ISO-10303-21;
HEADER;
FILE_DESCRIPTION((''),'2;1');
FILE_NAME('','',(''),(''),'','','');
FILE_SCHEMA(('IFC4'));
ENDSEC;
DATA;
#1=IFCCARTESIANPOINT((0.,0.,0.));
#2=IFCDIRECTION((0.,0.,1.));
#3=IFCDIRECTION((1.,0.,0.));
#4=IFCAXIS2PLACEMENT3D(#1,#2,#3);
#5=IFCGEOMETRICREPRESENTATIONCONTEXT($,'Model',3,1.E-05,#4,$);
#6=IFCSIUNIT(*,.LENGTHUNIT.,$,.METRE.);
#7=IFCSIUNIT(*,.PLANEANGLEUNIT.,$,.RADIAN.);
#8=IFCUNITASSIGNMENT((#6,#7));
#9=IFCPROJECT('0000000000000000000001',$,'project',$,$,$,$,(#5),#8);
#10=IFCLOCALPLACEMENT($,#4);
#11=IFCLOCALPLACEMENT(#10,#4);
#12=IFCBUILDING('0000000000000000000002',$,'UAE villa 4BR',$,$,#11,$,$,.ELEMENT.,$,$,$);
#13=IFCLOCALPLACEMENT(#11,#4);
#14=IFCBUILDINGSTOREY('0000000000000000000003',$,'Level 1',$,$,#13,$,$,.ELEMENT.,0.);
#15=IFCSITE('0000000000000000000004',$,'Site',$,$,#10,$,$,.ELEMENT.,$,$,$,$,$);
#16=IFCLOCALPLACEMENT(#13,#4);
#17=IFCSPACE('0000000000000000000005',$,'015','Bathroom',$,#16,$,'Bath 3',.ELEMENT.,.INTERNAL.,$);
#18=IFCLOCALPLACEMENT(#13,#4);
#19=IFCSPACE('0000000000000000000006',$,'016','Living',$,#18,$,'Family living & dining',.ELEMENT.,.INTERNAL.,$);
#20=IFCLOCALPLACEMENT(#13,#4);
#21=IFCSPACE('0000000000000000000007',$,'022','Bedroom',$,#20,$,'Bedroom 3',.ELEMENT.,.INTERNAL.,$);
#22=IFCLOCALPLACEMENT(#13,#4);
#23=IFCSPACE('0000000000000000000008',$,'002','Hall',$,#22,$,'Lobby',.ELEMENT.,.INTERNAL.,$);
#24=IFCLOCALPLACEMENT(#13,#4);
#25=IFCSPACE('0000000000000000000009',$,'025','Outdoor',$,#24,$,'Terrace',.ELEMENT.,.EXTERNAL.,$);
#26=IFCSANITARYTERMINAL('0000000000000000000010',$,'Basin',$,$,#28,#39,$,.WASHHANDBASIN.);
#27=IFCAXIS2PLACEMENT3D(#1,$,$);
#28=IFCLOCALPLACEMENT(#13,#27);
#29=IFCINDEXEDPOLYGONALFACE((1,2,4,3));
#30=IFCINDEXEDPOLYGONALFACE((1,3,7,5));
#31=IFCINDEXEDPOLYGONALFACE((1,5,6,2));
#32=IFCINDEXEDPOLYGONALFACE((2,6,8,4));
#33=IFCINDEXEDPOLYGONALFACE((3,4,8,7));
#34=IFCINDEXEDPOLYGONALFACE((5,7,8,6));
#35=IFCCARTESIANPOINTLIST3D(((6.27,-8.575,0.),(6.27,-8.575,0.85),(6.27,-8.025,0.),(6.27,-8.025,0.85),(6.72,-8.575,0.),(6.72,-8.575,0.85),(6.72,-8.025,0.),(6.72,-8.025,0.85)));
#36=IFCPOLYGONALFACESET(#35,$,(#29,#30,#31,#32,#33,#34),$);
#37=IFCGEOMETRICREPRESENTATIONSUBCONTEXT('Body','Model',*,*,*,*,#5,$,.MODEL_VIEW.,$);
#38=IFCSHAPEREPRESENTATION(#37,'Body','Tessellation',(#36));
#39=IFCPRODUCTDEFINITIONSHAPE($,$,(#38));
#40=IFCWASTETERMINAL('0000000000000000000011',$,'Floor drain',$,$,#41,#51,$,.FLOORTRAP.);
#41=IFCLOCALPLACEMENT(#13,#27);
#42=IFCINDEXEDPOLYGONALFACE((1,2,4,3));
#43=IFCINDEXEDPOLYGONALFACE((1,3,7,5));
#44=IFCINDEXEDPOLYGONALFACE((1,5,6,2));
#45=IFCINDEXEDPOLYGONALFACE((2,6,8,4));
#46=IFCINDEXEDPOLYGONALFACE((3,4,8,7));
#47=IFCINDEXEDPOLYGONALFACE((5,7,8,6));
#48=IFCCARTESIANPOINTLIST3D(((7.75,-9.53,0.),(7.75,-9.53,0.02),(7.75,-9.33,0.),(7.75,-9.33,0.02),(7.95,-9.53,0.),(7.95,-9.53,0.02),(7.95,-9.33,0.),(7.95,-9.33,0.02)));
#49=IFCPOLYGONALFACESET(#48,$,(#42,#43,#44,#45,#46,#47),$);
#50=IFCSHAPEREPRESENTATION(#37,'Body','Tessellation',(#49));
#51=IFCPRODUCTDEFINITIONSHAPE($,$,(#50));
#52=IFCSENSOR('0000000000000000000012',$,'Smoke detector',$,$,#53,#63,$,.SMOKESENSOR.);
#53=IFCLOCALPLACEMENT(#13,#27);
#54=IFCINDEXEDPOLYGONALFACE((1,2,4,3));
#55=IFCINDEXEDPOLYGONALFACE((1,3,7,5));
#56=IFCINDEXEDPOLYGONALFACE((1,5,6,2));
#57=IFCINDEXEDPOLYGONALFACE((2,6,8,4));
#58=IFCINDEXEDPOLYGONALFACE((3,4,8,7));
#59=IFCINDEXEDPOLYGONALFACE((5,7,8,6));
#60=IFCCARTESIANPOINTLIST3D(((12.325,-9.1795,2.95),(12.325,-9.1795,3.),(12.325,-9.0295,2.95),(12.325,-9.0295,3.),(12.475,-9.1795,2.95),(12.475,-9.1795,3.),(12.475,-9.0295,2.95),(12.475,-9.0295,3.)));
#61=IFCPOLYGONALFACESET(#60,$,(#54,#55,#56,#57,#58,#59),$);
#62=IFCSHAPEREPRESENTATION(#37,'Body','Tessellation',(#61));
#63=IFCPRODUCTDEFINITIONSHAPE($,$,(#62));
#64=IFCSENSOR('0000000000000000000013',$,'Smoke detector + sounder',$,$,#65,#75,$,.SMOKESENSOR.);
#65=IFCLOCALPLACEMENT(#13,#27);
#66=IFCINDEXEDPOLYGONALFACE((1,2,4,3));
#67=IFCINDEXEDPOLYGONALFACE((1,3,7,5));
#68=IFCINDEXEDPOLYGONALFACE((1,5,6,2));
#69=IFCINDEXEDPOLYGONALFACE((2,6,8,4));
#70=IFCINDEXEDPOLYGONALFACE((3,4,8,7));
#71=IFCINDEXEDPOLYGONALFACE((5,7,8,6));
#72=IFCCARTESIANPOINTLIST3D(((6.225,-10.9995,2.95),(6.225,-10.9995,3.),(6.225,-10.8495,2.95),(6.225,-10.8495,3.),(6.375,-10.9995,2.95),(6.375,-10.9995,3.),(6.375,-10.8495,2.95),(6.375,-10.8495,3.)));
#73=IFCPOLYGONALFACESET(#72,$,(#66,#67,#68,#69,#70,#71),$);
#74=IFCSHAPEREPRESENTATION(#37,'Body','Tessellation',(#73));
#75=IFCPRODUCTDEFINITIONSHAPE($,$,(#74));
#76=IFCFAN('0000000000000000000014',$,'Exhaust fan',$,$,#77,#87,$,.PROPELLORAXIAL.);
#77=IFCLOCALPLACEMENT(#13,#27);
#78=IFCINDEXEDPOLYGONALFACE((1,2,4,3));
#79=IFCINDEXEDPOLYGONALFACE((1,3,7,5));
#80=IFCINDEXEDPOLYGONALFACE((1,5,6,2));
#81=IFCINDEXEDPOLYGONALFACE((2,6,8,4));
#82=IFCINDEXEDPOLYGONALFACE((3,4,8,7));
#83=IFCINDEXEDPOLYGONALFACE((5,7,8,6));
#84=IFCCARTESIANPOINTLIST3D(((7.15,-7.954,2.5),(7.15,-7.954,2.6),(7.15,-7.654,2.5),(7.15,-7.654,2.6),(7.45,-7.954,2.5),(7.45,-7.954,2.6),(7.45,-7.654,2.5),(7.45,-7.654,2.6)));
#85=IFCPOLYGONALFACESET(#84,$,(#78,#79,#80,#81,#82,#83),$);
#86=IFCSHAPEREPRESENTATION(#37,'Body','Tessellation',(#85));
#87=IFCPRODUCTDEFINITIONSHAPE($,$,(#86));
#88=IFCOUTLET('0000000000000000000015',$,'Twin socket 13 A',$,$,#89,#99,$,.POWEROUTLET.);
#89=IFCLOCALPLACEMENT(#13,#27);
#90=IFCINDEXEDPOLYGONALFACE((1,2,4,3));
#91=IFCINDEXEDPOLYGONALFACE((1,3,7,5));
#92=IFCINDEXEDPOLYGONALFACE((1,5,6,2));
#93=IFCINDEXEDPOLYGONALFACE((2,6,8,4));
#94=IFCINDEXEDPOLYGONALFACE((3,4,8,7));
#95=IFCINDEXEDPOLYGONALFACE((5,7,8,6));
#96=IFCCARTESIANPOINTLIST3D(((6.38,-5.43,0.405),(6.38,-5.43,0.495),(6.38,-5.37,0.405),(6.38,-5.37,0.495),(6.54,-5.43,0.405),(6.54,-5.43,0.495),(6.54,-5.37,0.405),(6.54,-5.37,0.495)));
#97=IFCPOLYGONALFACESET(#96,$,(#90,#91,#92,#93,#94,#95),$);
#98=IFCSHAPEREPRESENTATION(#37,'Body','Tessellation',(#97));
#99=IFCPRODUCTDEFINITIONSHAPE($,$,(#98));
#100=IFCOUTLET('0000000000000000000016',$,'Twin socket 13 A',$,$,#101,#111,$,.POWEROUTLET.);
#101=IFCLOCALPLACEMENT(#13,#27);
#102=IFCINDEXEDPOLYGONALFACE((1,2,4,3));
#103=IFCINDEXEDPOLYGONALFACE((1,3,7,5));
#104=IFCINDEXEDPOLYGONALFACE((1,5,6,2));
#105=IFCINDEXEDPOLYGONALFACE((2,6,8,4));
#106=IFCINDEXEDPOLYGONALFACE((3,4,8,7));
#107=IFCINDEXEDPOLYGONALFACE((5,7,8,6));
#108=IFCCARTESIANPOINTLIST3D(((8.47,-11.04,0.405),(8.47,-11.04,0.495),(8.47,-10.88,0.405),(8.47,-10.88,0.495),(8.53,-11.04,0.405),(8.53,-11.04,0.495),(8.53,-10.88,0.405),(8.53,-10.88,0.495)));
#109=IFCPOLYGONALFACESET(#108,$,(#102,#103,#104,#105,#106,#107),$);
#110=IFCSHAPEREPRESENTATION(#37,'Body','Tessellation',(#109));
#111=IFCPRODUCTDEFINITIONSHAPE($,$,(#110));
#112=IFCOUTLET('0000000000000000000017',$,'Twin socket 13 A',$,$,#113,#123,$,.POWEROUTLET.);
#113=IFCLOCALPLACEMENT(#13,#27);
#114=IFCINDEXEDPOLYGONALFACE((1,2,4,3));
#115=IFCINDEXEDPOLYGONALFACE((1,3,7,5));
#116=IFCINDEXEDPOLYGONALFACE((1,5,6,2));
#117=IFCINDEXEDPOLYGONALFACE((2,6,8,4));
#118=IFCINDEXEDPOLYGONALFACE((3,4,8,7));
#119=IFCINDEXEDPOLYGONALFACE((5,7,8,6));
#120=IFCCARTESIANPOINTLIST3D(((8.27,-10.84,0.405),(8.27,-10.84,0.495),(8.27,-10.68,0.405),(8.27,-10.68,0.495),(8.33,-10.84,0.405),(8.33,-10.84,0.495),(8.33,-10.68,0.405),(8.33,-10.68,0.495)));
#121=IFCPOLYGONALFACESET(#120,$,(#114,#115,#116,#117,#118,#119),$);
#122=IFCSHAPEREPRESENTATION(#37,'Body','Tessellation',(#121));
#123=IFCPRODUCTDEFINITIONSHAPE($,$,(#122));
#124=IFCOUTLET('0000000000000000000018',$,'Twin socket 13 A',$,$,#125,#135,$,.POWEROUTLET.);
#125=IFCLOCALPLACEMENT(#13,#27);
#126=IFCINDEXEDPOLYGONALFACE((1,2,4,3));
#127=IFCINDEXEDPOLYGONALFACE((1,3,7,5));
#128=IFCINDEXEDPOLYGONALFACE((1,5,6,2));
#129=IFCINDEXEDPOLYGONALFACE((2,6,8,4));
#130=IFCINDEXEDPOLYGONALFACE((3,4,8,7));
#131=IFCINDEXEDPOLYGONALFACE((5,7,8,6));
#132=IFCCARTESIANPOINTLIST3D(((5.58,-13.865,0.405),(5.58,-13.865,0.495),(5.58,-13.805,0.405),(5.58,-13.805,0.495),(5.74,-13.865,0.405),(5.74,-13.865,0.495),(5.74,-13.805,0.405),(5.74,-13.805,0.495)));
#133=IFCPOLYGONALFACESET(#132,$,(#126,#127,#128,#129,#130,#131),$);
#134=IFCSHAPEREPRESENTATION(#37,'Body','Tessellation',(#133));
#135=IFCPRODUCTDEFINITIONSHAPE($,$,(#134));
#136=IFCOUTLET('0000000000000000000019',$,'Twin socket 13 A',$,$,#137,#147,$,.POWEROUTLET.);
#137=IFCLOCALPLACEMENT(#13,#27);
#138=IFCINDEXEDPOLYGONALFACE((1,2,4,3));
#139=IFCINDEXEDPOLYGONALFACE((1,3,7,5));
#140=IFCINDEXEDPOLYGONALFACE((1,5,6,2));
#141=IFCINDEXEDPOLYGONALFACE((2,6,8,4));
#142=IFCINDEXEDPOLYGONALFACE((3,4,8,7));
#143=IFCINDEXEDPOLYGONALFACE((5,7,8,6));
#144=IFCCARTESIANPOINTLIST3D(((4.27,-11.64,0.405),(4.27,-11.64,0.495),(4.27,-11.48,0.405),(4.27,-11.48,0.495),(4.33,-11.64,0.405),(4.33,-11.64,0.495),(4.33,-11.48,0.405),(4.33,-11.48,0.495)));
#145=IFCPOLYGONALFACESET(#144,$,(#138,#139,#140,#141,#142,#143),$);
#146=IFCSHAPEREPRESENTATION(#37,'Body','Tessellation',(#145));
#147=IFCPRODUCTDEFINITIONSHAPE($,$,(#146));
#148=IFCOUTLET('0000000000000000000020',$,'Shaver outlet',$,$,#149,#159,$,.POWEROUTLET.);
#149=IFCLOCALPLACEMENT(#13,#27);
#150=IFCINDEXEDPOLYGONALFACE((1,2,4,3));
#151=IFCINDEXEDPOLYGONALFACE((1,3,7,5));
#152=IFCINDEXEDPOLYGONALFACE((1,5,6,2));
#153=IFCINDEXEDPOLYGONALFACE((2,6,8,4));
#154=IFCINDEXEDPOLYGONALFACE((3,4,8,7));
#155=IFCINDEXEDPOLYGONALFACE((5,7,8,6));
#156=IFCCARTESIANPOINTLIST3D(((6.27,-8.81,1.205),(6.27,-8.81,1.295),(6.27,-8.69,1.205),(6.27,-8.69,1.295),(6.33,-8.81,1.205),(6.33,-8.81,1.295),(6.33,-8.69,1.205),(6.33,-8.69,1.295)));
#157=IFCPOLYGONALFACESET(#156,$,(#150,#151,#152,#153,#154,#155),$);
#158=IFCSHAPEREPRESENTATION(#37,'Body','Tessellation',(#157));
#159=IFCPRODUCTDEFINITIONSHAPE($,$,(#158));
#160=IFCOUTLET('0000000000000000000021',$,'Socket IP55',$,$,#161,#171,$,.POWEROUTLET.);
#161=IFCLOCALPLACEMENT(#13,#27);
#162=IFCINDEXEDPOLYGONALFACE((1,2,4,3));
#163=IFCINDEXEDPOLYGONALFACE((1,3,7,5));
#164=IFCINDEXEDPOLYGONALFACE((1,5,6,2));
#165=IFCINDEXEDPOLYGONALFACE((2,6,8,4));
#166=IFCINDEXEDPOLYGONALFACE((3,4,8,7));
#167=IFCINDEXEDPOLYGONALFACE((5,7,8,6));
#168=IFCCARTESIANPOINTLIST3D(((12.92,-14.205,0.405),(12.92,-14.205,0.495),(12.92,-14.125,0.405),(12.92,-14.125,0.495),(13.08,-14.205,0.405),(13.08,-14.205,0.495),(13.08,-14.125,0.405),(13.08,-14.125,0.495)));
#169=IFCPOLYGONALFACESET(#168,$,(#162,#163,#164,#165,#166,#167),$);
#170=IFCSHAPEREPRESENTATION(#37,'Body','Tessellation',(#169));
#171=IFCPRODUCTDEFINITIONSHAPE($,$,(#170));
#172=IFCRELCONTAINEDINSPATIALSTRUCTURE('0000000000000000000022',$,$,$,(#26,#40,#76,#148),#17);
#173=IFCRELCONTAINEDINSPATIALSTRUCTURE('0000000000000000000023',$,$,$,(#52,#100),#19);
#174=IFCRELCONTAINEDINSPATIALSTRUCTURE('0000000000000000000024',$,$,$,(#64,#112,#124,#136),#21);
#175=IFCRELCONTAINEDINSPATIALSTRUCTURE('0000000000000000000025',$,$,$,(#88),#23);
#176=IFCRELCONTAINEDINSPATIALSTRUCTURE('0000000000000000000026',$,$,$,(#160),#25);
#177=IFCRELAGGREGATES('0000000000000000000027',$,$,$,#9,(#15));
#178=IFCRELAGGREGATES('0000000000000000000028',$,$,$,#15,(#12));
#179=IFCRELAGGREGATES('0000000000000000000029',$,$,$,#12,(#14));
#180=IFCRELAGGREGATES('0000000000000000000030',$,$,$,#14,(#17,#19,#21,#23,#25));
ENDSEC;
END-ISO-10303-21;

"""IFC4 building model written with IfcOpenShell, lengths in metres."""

from ifc_helpers import new_model, si_unit, frame, origin, origin_with_axes, origin_2d, place, context, subcontext, project, spatial, rectangle, extrude, element, save


model = new_model("IFC4")

# Units and contexts
model_context = context("Model", 3, precision=1e-05, world=origin_with_axes())
body_context = subcontext(model_context, "Body", "Model", "MODEL_VIEW")
ifc_project = project(units=[si_unit("LENGTHUNIT", "METRE"), si_unit("PLANEANGLEUNIT", "RADIAN")], contexts=[model_context])

# Site, building, storey
site_placement = place(None, origin_with_axes())
site = spatial("IfcSite", under=ifc_project, at=site_placement, Name="Site", CompositionType="ELEMENT")
building_placement = place(site_placement, origin_with_axes())
building = spatial("IfcBuilding", under=site, at=building_placement, Name="UAE villa 4BR", CompositionType="ELEMENT")
storey_placement = place(building_placement, origin_with_axes())
storey = spatial("IfcBuildingStorey", under=building, at=storey_placement, Name="Level 1", CompositionType="ELEMENT", Elevation=0.0)

# Shared definitions
space_1_placement = place(storey_placement, origin_with_axes())
space_1 = spatial("IfcSpace", under=storey, at=space_1_placement, Name="015", Description="Bathroom", LongName="Bath 3", CompositionType="ELEMENT", PredefinedType="INTERNAL")

# Sanitary terminal
sanitary_terminal_1_placement = place(storey_placement, frame((6.495, -8.3, 0.0), z_axis=(0.0, 0.0, 1.0), x_axis=(0.0, 1.0, 0.0)))
element("IfcSanitaryTerminal", 1, at=sanitary_terminal_1_placement, inside=space_1, Name="Basin", PredefinedType="WASHHANDBASIN", context=body_context, shape_type="SweptSolid", body=[
    extrude(rectangle(XDim=0.55, YDim=0.45, at=origin_2d()), origin(), (0.0, 0.0, 1.0), 0.85),
])

# Waste terminal
waste_terminal_placement = place(storey_placement, frame((7.85, -9.43, 0.0), z_axis=(0.0, 0.0, 1.0), x_axis=(-1.0, 0.0, 0.0)))
element("IfcWasteTerminal", 2, at=waste_terminal_placement, inside=space_1, Name="Floor drain", PredefinedType="FLOORTRAP", context=body_context, shape_type="SweptSolid", body=[
    extrude(rectangle(XDim=0.2, YDim=0.2, at=origin_2d()), origin(), (0.0, 0.0, 1.0), 0.02),
])

# Shared definitions
space_2_placement = place(storey_placement, origin_with_axes())
space_2 = spatial("IfcSpace", under=storey, at=space_2_placement, Name="016", Description="Living", LongName="Family living & dining", CompositionType="ELEMENT", PredefinedType="INTERNAL")

# Sensor
sensor_1_placement = place(storey_placement, frame((12.4, -9.1045, 2.95), z_axis=(0.0, 0.0, 1.0), x_axis=(1.0, 0.0, 0.0)))
element("IfcSensor", 3, at=sensor_1_placement, inside=space_2, Name="Smoke detector", PredefinedType="SMOKESENSOR", context=body_context, shape_type="SweptSolid", body=[
    extrude(rectangle(XDim=0.15, YDim=0.15, at=origin_2d()), origin(), (0.0, 0.0, 1.0), 0.05),
])

# Shared definitions
space_3_placement = place(storey_placement, origin_with_axes())
space_3 = spatial("IfcSpace", under=storey, at=space_3_placement, Name="022", Description="Bedroom", LongName="Bedroom 3", CompositionType="ELEMENT", PredefinedType="INTERNAL")

# Sensor
sensor_2_placement = place(storey_placement, frame((6.3, -10.9245, 2.95), z_axis=(0.0, 0.0, 1.0), x_axis=(1.0, 0.0, 0.0)))
element("IfcSensor", 4, at=sensor_2_placement, inside=space_3, Name="Smoke detector + sounder", PredefinedType="SMOKESENSOR", context=body_context, shape_type="SweptSolid", body=[
    extrude(rectangle(XDim=0.15, YDim=0.15, at=origin_2d()), origin(), (0.0, 0.0, 1.0), 0.05),
])

# Fan
fan_placement = place(storey_placement, frame((7.3, -7.804, 2.5), z_axis=(0.0, 0.0, 1.0), x_axis=(1.0, 0.0, 0.0)))
element("IfcFan", 5, at=fan_placement, inside=space_1, Name="Exhaust fan", PredefinedType="PROPELLORAXIAL", context=body_context, shape_type="SweptSolid", body=[
    extrude(rectangle(XDim=0.3, YDim=0.3, at=origin_2d()), origin(), (0.0, 0.0, 1.0), 0.1),
])

# Shared definitions
space_4_placement = place(storey_placement, origin_with_axes())
space_4 = spatial("IfcSpace", under=storey, at=space_4_placement, Name="002", Description="Hall", LongName="Lobby", CompositionType="ELEMENT", PredefinedType="INTERNAL")

# Outlets
outlet_1_placement = place(storey_placement, frame((6.46, -5.4, 0.405), z_axis=(0.0, 0.0, 1.0), x_axis=(-1.0, 0.0, 0.0)))
element("IfcOutlet", 6, at=outlet_1_placement, inside=space_4, Name="Twin socket 13 A", PredefinedType="POWEROUTLET", context=body_context, shape_type="SweptSolid", body=[
    extrude(rectangle(XDim=0.16, YDim=0.06, at=origin_2d()), origin(), (0.0, 0.0, 1.0), 0.09),
])
outlet_2_placement = place(storey_placement, frame((8.5, -10.96, 0.405), z_axis=(0.0, 0.0, 1.0), x_axis=(0.0, 1.0, 0.0)))
element("IfcOutlet", 7, at=outlet_2_placement, inside=space_2, Name="Twin socket 13 A", PredefinedType="POWEROUTLET", context=body_context, shape_type="SweptSolid", body=[
    extrude(rectangle(XDim=0.16, YDim=0.06, at=origin_2d()), origin(), (0.0, 0.0, 1.0), 0.09),
])
for number, where, z_axis, x_axis, name in (
    (8, (8.3, -10.76, 0.405), (0.0, 0.0, 1.0), (0.0, -1.0, 0.0), "Twin socket 13 A"),
    (9, (5.66, -13.835, 0.405), (0.0, 0.0, 1.0), (-1.0, 0.0, 0.0), "Twin socket 13 A"),
    (10, (4.3, -11.56, 0.405), (0.0, 0.0, 1.0), (0.0, 1.0, 0.0), "Twin socket 13 A"),
):
    element("IfcOutlet", number, at=place(storey_placement, frame(where, z_axis=z_axis, x_axis=x_axis)), inside=space_3, Name=name, PredefinedType="POWEROUTLET", context=body_context, shape_type="SweptSolid", body=[
        extrude(rectangle(XDim=0.16, YDim=0.06, at=origin_2d()), origin(), (0.0, 0.0, 1.0), 0.09),
    ])
outlet_3_placement = place(storey_placement, frame((6.3, -8.75, 1.205), z_axis=(0.0, 0.0, 1.0), x_axis=(0.0, 1.0, 0.0)))
element("IfcOutlet", 11, at=outlet_3_placement, inside=space_1, Name="Shaver outlet", PredefinedType="POWEROUTLET", context=body_context, shape_type="SweptSolid", body=[
    extrude(rectangle(XDim=0.12, YDim=0.06, at=origin_2d()), origin(), (0.0, 0.0, 1.0), 0.09),
])

# Shared definitions
space_5_placement = place(storey_placement, origin_with_axes())
space_5 = spatial("IfcSpace", under=storey, at=space_5_placement, Name="025", Description="Outdoor", LongName="Terrace", CompositionType="ELEMENT", PredefinedType="EXTERNAL")

# Outlet
outlet_4_placement = place(storey_placement, frame((13.0, -14.165, 0.405), z_axis=(0.0, 0.0, 1.0), x_axis=(1.0, 0.0, 0.0)))
element("IfcOutlet", 12, at=outlet_4_placement, inside=space_5, Name="Socket IP55", PredefinedType="POWEROUTLET", context=body_context, shape_type="SweptSolid", body=[
    extrude(rectangle(XDim=0.16, YDim=0.08, at=origin_2d()), origin(), (0.0, 0.0, 1.0), 0.09),
])

save(model, "model.ifc")
